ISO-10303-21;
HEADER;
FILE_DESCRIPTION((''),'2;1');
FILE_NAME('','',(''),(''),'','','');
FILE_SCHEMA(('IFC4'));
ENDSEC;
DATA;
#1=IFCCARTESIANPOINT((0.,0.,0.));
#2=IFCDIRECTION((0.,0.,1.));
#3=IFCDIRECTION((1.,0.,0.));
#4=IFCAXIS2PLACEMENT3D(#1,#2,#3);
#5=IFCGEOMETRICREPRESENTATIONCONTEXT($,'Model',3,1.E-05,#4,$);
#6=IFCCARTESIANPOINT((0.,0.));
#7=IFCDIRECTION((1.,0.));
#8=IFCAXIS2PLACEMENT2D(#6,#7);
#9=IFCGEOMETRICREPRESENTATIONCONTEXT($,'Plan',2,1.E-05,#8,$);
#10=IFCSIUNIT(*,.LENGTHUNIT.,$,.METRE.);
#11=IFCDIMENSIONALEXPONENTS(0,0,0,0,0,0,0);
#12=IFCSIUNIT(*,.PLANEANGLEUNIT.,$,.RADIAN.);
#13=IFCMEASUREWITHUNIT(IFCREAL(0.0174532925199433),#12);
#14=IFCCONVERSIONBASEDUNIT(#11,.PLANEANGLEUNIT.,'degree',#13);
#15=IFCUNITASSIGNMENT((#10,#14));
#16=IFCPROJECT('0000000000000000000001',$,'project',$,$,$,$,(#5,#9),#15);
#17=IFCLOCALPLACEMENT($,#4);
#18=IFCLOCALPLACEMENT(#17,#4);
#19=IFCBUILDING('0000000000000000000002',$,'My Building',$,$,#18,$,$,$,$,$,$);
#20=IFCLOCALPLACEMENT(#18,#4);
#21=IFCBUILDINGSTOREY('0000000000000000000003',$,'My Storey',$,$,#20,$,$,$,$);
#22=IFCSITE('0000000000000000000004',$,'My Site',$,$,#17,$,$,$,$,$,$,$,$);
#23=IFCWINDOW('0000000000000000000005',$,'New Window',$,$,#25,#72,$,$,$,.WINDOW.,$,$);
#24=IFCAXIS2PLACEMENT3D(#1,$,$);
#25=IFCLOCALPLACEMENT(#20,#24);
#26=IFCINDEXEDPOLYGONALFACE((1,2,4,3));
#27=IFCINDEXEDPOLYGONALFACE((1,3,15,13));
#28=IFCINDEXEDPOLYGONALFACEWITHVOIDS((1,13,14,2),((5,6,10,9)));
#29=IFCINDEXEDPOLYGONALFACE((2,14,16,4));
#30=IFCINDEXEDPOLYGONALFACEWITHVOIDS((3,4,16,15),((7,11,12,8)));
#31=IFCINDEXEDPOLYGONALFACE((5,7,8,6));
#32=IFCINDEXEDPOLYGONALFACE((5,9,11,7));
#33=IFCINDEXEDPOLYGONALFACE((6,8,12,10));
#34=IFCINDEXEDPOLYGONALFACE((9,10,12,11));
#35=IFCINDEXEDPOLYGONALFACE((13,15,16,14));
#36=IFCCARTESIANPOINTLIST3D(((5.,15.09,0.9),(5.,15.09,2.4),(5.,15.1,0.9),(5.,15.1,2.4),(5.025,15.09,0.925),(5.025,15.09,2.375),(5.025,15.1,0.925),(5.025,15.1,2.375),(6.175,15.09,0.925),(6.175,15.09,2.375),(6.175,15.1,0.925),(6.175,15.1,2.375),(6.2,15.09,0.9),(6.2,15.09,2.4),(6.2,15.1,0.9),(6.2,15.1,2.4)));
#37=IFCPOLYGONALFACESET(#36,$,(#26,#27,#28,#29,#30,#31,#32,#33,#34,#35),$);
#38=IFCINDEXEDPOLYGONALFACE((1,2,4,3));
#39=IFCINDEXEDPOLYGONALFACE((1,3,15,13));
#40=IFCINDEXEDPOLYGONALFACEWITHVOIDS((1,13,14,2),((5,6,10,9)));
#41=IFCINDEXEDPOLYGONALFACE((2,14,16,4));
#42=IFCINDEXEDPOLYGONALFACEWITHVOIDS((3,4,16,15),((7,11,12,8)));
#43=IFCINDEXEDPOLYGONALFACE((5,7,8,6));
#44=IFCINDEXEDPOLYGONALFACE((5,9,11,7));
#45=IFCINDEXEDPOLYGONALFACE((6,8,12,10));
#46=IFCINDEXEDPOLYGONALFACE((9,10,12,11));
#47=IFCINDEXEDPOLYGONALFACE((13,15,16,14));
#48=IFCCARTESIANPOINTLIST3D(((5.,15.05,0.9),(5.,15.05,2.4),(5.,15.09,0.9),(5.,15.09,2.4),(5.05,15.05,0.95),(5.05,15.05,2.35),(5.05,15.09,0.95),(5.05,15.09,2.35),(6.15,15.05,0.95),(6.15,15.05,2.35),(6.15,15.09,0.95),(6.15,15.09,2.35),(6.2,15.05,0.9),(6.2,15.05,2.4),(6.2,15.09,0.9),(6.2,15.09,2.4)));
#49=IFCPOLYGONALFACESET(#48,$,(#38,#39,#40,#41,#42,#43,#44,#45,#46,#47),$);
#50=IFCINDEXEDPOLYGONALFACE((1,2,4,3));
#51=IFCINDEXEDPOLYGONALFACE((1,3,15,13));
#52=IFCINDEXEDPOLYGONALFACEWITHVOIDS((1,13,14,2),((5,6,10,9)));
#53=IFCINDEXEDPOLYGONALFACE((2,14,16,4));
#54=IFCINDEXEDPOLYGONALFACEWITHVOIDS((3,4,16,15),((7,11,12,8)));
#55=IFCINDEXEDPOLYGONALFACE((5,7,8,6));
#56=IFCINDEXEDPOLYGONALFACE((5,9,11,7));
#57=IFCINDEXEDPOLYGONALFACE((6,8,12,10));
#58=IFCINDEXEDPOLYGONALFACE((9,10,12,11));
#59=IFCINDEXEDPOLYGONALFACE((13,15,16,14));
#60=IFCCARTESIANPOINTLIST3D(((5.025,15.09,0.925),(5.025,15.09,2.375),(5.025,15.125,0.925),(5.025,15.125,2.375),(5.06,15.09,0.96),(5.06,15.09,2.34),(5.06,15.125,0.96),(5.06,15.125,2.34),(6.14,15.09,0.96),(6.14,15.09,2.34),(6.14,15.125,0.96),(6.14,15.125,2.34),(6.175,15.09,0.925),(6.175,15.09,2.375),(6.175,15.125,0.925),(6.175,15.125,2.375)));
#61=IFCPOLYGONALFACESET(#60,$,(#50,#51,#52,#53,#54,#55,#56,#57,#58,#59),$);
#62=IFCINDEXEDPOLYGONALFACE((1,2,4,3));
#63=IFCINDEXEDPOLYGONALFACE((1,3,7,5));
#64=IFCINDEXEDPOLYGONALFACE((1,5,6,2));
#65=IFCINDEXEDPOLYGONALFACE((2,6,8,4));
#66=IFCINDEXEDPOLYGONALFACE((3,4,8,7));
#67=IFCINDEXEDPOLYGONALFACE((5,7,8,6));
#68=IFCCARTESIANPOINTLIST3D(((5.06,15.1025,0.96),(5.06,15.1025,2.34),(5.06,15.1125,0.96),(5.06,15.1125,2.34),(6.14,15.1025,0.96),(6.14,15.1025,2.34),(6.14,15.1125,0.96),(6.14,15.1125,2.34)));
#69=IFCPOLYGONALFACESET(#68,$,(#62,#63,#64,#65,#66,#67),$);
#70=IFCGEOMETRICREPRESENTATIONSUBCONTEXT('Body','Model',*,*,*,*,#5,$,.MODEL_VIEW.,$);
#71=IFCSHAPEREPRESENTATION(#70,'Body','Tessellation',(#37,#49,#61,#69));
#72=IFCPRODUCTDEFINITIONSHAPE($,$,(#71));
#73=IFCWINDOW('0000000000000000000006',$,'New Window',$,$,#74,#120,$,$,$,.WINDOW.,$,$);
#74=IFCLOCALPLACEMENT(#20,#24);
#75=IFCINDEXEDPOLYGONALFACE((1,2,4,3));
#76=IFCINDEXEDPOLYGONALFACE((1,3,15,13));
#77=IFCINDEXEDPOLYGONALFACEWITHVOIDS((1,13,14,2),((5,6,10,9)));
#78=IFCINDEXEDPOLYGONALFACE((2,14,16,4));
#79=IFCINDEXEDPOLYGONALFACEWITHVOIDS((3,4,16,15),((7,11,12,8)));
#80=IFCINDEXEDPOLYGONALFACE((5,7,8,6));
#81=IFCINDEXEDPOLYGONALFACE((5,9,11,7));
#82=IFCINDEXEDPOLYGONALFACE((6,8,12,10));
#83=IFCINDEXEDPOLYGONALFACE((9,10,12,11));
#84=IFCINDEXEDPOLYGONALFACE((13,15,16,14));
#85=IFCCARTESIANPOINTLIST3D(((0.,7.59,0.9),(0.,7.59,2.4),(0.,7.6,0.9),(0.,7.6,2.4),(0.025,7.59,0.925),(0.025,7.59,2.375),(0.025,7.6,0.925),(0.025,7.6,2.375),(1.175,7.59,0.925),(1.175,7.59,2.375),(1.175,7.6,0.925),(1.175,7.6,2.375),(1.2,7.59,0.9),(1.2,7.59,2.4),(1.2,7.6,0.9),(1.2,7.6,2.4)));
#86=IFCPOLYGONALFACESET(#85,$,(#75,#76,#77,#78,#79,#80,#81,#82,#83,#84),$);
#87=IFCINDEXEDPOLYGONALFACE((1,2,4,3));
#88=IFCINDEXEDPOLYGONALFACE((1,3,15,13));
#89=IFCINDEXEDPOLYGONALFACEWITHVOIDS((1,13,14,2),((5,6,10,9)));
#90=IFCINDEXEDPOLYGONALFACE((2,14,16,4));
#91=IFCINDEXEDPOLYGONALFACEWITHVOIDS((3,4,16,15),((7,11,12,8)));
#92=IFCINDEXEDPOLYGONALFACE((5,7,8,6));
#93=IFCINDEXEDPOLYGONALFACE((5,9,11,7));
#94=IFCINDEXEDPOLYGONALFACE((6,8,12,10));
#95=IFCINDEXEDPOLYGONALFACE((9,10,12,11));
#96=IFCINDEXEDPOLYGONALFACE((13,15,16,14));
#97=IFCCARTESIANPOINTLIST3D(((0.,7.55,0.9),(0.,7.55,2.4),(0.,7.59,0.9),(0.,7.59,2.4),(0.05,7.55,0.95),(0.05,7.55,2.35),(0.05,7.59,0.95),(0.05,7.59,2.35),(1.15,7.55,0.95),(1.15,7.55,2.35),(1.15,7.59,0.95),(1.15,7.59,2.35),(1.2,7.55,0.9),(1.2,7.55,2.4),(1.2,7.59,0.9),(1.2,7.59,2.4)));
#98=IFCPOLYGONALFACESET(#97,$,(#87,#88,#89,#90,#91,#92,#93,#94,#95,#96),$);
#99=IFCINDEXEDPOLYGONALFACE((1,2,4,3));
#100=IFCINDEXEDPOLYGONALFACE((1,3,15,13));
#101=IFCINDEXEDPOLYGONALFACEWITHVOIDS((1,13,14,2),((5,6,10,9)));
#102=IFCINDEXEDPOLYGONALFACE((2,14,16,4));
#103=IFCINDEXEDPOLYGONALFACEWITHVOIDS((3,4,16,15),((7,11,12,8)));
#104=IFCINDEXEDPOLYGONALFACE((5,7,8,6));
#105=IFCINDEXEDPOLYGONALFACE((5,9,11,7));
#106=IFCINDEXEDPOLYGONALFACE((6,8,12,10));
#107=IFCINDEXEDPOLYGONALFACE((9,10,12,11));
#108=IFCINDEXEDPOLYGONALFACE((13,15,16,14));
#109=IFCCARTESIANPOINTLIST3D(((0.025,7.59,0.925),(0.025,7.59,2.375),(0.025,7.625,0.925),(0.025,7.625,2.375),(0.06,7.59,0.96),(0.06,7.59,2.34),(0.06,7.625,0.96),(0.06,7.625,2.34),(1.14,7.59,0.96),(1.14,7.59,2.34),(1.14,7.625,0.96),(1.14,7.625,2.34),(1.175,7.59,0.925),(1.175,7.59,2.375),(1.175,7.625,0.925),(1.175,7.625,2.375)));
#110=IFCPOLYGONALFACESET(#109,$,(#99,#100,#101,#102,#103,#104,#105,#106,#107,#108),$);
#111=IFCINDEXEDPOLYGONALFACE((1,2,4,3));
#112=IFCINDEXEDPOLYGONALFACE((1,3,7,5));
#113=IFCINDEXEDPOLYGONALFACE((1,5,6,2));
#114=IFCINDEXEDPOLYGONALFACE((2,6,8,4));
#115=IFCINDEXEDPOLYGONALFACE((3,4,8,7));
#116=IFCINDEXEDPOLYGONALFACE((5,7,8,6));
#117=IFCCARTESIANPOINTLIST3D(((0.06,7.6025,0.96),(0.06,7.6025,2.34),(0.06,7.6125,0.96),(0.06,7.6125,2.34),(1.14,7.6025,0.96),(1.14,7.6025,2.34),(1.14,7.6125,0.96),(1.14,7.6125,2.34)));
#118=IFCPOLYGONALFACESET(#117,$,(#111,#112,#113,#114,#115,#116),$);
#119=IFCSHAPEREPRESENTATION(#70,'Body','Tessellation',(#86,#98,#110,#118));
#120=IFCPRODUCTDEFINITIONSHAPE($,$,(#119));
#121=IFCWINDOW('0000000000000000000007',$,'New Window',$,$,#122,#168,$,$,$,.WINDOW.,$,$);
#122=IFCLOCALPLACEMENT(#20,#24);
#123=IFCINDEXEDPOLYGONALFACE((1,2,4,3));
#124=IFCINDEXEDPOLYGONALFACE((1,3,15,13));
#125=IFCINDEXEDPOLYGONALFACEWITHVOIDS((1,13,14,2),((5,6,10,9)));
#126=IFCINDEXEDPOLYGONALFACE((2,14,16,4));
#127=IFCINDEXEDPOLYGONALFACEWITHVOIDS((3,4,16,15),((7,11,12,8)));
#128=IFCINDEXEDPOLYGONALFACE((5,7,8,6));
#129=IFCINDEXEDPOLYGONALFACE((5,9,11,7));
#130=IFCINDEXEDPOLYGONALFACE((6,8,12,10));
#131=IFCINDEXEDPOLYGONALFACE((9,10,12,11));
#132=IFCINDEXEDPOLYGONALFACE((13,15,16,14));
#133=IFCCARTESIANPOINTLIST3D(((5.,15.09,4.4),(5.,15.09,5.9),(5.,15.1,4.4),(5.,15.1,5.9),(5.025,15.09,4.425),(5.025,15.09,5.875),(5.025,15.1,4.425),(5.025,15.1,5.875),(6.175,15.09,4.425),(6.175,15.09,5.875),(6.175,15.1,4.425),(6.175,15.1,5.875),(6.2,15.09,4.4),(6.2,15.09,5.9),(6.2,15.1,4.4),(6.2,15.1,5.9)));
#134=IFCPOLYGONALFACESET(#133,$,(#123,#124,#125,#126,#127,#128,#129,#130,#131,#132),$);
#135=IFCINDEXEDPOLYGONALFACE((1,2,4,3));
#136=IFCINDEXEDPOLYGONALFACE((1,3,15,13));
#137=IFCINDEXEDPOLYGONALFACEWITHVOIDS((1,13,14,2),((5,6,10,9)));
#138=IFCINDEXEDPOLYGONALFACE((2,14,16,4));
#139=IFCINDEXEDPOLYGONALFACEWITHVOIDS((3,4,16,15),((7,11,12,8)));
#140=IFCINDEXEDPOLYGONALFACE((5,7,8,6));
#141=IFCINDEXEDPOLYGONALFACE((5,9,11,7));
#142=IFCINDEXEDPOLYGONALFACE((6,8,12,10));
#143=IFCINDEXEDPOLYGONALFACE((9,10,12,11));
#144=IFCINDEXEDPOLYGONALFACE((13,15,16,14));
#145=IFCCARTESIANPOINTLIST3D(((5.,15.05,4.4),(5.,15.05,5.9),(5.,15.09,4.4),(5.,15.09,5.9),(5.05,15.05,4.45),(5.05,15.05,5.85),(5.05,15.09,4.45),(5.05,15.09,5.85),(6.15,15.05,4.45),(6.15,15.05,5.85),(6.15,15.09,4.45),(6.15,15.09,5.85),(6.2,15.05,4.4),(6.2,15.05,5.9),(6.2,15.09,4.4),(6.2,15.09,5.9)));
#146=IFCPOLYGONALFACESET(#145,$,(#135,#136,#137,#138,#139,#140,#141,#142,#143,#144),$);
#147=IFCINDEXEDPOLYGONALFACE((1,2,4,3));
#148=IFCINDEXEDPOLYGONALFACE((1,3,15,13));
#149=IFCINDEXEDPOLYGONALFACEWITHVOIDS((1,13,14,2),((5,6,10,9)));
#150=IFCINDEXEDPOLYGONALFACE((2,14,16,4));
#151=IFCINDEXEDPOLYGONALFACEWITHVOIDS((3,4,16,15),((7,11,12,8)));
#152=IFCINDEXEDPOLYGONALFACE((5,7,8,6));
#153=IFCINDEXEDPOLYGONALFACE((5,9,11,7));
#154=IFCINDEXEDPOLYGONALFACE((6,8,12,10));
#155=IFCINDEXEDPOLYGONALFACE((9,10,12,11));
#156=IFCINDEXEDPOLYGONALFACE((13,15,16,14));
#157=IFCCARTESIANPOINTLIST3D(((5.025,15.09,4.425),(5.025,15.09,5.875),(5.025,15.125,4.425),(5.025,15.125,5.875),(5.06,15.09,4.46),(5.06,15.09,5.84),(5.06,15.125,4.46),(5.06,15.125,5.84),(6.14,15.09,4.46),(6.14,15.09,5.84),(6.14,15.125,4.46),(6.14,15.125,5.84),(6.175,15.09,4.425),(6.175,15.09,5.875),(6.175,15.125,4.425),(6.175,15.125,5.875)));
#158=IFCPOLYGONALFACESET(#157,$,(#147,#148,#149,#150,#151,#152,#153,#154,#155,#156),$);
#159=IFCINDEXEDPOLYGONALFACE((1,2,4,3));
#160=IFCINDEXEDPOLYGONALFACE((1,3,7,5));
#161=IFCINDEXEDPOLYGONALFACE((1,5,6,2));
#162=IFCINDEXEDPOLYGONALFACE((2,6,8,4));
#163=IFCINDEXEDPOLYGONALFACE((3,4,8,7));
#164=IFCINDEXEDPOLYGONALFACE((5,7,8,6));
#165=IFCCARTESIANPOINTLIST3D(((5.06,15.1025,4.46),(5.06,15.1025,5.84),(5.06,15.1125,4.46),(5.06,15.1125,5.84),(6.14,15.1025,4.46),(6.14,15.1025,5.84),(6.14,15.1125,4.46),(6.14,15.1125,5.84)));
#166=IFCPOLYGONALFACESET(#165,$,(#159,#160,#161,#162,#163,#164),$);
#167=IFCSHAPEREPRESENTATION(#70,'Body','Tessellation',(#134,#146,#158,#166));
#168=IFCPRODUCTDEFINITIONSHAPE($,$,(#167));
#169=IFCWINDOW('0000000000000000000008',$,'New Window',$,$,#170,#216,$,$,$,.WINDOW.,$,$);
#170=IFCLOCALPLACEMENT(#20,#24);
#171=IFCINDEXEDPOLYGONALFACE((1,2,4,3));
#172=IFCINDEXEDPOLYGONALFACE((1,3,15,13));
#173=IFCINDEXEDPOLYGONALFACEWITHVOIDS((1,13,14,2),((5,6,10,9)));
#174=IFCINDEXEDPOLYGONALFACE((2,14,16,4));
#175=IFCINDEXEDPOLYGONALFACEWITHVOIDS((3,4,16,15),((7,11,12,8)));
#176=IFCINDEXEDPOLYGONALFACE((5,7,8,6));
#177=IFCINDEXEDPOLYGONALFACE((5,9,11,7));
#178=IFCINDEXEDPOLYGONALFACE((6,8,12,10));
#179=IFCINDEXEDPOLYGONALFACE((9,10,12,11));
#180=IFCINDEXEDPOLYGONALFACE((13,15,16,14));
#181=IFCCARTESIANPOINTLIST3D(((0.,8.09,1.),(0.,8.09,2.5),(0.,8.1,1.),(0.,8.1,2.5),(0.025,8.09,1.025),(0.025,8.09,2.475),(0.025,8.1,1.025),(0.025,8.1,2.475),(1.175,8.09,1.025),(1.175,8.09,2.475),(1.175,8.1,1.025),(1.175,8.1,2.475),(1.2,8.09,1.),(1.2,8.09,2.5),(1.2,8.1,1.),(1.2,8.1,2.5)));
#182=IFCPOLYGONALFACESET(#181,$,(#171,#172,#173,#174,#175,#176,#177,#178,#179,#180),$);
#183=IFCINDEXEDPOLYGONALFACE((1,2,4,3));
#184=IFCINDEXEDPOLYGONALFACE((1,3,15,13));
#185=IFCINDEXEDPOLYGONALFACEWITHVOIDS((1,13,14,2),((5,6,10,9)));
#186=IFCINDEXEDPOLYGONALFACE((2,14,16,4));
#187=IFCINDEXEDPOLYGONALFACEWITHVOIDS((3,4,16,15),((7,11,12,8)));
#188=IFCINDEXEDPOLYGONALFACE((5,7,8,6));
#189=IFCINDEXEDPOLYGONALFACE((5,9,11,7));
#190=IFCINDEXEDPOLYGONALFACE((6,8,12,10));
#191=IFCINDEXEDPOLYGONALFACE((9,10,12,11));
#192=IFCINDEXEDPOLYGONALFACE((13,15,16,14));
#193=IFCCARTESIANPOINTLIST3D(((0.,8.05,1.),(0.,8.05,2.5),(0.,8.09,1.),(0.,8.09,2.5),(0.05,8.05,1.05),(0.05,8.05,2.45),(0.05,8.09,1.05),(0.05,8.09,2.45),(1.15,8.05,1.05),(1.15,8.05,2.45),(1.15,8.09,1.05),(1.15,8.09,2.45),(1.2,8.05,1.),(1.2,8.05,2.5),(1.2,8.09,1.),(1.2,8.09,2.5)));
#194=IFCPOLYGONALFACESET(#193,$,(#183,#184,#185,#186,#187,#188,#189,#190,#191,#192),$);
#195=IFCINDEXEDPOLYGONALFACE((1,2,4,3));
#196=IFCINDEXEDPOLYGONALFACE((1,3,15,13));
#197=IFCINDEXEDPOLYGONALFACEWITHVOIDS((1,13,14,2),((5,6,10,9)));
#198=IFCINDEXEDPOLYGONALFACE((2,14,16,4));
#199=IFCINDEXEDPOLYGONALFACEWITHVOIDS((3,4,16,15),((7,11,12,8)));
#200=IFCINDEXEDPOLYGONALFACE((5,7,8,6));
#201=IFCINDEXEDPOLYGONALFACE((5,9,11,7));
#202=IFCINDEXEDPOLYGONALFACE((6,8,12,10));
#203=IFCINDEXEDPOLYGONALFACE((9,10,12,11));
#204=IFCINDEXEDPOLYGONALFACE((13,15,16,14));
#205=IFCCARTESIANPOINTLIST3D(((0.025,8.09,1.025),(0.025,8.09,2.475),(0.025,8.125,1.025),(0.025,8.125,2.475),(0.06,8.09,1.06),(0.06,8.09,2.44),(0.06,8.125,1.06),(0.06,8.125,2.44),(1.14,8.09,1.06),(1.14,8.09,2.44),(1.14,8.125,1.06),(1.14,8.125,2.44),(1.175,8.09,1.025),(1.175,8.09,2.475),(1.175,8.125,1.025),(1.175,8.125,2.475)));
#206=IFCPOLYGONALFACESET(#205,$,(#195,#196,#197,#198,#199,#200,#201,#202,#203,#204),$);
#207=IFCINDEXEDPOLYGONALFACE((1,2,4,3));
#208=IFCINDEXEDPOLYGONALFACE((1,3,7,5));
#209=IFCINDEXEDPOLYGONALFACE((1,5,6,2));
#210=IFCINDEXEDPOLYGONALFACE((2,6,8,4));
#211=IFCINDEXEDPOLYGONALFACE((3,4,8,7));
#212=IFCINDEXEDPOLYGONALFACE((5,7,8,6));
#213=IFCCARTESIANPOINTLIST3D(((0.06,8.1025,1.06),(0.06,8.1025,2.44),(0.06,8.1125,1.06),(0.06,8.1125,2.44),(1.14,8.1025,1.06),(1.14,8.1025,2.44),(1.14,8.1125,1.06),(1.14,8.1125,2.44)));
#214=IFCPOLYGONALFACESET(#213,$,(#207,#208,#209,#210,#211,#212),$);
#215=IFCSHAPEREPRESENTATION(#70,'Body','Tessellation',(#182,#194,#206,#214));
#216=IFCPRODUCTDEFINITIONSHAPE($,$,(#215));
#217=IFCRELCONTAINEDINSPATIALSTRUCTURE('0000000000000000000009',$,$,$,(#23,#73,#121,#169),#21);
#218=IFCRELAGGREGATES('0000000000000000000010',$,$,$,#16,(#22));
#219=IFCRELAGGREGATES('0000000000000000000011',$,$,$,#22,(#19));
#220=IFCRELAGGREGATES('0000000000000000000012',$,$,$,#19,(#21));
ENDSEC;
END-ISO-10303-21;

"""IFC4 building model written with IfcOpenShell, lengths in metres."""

from ifc_helpers import new_model, entity, si_unit, converted_unit, frame, origin_with_axes, origin_2d_with_axis, place, context, subcontext, project, spatial, line, indexed_curve, outline, extrude, element, save


model = new_model("IFC4")

# Units and contexts
model_context = context("Model", 3, precision=1e-05, world=origin_with_axes())
plan_context = context("Plan", 2, precision=1e-05, world=origin_2d_with_axis())
body_context = subcontext(model_context, "Body", "Model", "MODEL_VIEW")
ifc_project = project(units=[si_unit("LENGTHUNIT", "METRE"), converted_unit("PLANEANGLEUNIT", "degree", entity("IfcReal", 0.0174532925199433), si_unit("PLANEANGLEUNIT", "RADIAN"), dimensions=[0, 0, 0, 0, 0, 0, 0])], contexts=[model_context, plan_context])

# Site, building, storey
site_placement = place(None, origin_with_axes())
site = spatial("IfcSite", under=ifc_project, at=site_placement, Name="My Site")
building_placement = place(site_placement, origin_with_axes())
building = spatial("IfcBuilding", under=site, at=building_placement, Name="My Building")
storey_placement = place(building_placement, origin_with_axes())
storey = spatial("IfcBuildingStorey", under=building, at=storey_placement, Name="My Storey")

# Windows
for number, where, z_axis, x_axis, name in (
    (1, (5.0, 15.0, 0.9), (0.0, 0.0, 1.0), (1.0, 0.0, 0.0), "New Window"),
    (2, (0.0, 7.5, 0.9), (0.0, 0.0, 1.0), (1.0, 0.0, 0.0), "New Window"),
    (3, (5.0, 15.0, 4.4), (0.0, 0.0, 1.0), (1.0, 0.0, 0.0), "New Window"),
):
    element("IfcWindow", number, at=place(storey_placement, frame(where, z_axis=z_axis, x_axis=x_axis)), inside=storey, Name=name, PredefinedType="WINDOW", context=body_context, shape_type="SweptSolid", body=[
        extrude(outline(indexed_curve([(0.0, 0.0), (1.2, 0.0), (1.2, 1.5), (0.0, 1.5)], segments=[line(1, 2, 3, 4, 1)]), holes=[indexed_curve([(0.025, 0.025), (1.175, 0.025), (1.175, 1.475), (0.025, 1.475)], segments=[line(1, 2, 3, 4, 1)])]), frame((0.0, 0.09, 0.0), z_axis=(0.0, -1.0, 0.0), x_axis=(1.0, 0.0, 0.0)), (0.0, 0.0, -1.0), 0.01),
        extrude(outline(indexed_curve([(0.0, 0.0), (1.2, 0.0), (1.2, 1.5), (0.0, 1.5)], segments=[line(1, 2, 3, 4, 1)]), holes=[indexed_curve([(0.05, 0.05), (1.15, 0.05), (1.15, 1.45), (0.05, 1.45)], segments=[line(1, 2, 3, 4, 1)])]), frame((0.0, 0.05, 0.0), z_axis=(0.0, -1.0, 0.0), x_axis=(1.0, 0.0, 0.0)), (0.0, 0.0, -1.0), 0.04),
        extrude(outline(indexed_curve([(0.0, 0.0), (1.15, 0.0), (1.15, 1.45), (0.0, 1.45)], segments=[line(1, 2, 3, 4, 1)]), holes=[indexed_curve([(0.035, 0.035), (1.115, 0.035), (1.115, 1.415), (0.035, 1.415)], segments=[line(1, 2, 3, 4, 1)])]), frame((0.025, 0.09, 0.025), z_axis=(0.0, -1.0, 0.0), x_axis=(1.0, 0.0, 0.0)), (0.0, 0.0, -1.0), 0.035),
        extrude(outline(indexed_curve([(0.035, 0.035), (1.115, 0.035), (1.115, 1.415), (0.035, 1.415)], segments=[line(1, 2, 3, 4, 1)])), frame((0.025, 0.1025, 0.025), z_axis=(0.0, -1.0, 0.0), x_axis=(1.0, 0.0, 0.0)), (0.0, 0.0, -1.0), 0.01),
    ])

# Window
for number, where, z_axis, x_axis, name in (
    (4, (0.0, 8.0, 1.0), (0.0, 0.0, 1.0), (1.0, 0.0, 0.0), "New Window"),
):
    element("IfcWindow", number, at=place(storey_placement, frame(where, z_axis=z_axis, x_axis=x_axis)), inside=storey, Name=name, PredefinedType="WINDOW", context=body_context, shape_type="SweptSolid", body=[
        extrude(outline(indexed_curve([(0.0, 0.0), (1.2, 0.0), (1.2, 1.5), (0.0, 1.5)], segments=[line(1, 2, 3, 4, 1)]), holes=[indexed_curve([(0.025, 0.025), (1.175, 0.025), (1.175, 1.475), (0.025, 1.475)], segments=[line(1, 2, 3, 4, 1)])]), frame((0.0, 0.09, 0.0), z_axis=(0.0, -1.0, 0.0), x_axis=(1.0, 0.0, 0.0)), (0.0, 0.0, -1.0), 0.01),
        extrude(outline(indexed_curve([(0.0, 0.0), (1.2, 0.0), (1.2, 1.5), (0.0, 1.5)], segments=[line(1, 2, 3, 4, 1)]), holes=[indexed_curve([(0.05, 0.05), (1.15, 0.05), (1.15, 1.45), (0.05, 1.45)], segments=[line(1, 2, 3, 4, 1)])]), frame((0.0, 0.05, 0.0), z_axis=(0.0, -1.0, 0.0), x_axis=(1.0, 0.0, 0.0)), (0.0, 0.0, -1.0), 0.04),
        extrude(outline(indexed_curve([(0.0, 0.0), (1.15, 0.0), (1.15, 1.45), (0.0, 1.45)], segments=[line(1, 2, 3, 4, 1)]), holes=[indexed_curve([(0.035, 0.035), (1.115, 0.035), (1.115, 1.415), (0.035, 1.415)], segments=[line(1, 2, 3, 4, 1)])]), frame((0.025, 0.09, 0.025), z_axis=(0.0, -1.0, 0.0), x_axis=(1.0, 0.0, 0.0)), (0.0, 0.0, -1.0), 0.035),
        extrude(outline(indexed_curve([(0.035, 0.035), (1.115, 0.035), (1.115, 1.415), (0.035, 1.415)], segments=[line(1, 2, 3, 4, 1)])), frame((0.025, 0.1025, 0.025), z_axis=(0.0, -1.0, 0.0), x_axis=(1.0, 0.0, 0.0)), (0.0, 0.0, -1.0), 0.01),
    ])

save(model, "model.ifc")
